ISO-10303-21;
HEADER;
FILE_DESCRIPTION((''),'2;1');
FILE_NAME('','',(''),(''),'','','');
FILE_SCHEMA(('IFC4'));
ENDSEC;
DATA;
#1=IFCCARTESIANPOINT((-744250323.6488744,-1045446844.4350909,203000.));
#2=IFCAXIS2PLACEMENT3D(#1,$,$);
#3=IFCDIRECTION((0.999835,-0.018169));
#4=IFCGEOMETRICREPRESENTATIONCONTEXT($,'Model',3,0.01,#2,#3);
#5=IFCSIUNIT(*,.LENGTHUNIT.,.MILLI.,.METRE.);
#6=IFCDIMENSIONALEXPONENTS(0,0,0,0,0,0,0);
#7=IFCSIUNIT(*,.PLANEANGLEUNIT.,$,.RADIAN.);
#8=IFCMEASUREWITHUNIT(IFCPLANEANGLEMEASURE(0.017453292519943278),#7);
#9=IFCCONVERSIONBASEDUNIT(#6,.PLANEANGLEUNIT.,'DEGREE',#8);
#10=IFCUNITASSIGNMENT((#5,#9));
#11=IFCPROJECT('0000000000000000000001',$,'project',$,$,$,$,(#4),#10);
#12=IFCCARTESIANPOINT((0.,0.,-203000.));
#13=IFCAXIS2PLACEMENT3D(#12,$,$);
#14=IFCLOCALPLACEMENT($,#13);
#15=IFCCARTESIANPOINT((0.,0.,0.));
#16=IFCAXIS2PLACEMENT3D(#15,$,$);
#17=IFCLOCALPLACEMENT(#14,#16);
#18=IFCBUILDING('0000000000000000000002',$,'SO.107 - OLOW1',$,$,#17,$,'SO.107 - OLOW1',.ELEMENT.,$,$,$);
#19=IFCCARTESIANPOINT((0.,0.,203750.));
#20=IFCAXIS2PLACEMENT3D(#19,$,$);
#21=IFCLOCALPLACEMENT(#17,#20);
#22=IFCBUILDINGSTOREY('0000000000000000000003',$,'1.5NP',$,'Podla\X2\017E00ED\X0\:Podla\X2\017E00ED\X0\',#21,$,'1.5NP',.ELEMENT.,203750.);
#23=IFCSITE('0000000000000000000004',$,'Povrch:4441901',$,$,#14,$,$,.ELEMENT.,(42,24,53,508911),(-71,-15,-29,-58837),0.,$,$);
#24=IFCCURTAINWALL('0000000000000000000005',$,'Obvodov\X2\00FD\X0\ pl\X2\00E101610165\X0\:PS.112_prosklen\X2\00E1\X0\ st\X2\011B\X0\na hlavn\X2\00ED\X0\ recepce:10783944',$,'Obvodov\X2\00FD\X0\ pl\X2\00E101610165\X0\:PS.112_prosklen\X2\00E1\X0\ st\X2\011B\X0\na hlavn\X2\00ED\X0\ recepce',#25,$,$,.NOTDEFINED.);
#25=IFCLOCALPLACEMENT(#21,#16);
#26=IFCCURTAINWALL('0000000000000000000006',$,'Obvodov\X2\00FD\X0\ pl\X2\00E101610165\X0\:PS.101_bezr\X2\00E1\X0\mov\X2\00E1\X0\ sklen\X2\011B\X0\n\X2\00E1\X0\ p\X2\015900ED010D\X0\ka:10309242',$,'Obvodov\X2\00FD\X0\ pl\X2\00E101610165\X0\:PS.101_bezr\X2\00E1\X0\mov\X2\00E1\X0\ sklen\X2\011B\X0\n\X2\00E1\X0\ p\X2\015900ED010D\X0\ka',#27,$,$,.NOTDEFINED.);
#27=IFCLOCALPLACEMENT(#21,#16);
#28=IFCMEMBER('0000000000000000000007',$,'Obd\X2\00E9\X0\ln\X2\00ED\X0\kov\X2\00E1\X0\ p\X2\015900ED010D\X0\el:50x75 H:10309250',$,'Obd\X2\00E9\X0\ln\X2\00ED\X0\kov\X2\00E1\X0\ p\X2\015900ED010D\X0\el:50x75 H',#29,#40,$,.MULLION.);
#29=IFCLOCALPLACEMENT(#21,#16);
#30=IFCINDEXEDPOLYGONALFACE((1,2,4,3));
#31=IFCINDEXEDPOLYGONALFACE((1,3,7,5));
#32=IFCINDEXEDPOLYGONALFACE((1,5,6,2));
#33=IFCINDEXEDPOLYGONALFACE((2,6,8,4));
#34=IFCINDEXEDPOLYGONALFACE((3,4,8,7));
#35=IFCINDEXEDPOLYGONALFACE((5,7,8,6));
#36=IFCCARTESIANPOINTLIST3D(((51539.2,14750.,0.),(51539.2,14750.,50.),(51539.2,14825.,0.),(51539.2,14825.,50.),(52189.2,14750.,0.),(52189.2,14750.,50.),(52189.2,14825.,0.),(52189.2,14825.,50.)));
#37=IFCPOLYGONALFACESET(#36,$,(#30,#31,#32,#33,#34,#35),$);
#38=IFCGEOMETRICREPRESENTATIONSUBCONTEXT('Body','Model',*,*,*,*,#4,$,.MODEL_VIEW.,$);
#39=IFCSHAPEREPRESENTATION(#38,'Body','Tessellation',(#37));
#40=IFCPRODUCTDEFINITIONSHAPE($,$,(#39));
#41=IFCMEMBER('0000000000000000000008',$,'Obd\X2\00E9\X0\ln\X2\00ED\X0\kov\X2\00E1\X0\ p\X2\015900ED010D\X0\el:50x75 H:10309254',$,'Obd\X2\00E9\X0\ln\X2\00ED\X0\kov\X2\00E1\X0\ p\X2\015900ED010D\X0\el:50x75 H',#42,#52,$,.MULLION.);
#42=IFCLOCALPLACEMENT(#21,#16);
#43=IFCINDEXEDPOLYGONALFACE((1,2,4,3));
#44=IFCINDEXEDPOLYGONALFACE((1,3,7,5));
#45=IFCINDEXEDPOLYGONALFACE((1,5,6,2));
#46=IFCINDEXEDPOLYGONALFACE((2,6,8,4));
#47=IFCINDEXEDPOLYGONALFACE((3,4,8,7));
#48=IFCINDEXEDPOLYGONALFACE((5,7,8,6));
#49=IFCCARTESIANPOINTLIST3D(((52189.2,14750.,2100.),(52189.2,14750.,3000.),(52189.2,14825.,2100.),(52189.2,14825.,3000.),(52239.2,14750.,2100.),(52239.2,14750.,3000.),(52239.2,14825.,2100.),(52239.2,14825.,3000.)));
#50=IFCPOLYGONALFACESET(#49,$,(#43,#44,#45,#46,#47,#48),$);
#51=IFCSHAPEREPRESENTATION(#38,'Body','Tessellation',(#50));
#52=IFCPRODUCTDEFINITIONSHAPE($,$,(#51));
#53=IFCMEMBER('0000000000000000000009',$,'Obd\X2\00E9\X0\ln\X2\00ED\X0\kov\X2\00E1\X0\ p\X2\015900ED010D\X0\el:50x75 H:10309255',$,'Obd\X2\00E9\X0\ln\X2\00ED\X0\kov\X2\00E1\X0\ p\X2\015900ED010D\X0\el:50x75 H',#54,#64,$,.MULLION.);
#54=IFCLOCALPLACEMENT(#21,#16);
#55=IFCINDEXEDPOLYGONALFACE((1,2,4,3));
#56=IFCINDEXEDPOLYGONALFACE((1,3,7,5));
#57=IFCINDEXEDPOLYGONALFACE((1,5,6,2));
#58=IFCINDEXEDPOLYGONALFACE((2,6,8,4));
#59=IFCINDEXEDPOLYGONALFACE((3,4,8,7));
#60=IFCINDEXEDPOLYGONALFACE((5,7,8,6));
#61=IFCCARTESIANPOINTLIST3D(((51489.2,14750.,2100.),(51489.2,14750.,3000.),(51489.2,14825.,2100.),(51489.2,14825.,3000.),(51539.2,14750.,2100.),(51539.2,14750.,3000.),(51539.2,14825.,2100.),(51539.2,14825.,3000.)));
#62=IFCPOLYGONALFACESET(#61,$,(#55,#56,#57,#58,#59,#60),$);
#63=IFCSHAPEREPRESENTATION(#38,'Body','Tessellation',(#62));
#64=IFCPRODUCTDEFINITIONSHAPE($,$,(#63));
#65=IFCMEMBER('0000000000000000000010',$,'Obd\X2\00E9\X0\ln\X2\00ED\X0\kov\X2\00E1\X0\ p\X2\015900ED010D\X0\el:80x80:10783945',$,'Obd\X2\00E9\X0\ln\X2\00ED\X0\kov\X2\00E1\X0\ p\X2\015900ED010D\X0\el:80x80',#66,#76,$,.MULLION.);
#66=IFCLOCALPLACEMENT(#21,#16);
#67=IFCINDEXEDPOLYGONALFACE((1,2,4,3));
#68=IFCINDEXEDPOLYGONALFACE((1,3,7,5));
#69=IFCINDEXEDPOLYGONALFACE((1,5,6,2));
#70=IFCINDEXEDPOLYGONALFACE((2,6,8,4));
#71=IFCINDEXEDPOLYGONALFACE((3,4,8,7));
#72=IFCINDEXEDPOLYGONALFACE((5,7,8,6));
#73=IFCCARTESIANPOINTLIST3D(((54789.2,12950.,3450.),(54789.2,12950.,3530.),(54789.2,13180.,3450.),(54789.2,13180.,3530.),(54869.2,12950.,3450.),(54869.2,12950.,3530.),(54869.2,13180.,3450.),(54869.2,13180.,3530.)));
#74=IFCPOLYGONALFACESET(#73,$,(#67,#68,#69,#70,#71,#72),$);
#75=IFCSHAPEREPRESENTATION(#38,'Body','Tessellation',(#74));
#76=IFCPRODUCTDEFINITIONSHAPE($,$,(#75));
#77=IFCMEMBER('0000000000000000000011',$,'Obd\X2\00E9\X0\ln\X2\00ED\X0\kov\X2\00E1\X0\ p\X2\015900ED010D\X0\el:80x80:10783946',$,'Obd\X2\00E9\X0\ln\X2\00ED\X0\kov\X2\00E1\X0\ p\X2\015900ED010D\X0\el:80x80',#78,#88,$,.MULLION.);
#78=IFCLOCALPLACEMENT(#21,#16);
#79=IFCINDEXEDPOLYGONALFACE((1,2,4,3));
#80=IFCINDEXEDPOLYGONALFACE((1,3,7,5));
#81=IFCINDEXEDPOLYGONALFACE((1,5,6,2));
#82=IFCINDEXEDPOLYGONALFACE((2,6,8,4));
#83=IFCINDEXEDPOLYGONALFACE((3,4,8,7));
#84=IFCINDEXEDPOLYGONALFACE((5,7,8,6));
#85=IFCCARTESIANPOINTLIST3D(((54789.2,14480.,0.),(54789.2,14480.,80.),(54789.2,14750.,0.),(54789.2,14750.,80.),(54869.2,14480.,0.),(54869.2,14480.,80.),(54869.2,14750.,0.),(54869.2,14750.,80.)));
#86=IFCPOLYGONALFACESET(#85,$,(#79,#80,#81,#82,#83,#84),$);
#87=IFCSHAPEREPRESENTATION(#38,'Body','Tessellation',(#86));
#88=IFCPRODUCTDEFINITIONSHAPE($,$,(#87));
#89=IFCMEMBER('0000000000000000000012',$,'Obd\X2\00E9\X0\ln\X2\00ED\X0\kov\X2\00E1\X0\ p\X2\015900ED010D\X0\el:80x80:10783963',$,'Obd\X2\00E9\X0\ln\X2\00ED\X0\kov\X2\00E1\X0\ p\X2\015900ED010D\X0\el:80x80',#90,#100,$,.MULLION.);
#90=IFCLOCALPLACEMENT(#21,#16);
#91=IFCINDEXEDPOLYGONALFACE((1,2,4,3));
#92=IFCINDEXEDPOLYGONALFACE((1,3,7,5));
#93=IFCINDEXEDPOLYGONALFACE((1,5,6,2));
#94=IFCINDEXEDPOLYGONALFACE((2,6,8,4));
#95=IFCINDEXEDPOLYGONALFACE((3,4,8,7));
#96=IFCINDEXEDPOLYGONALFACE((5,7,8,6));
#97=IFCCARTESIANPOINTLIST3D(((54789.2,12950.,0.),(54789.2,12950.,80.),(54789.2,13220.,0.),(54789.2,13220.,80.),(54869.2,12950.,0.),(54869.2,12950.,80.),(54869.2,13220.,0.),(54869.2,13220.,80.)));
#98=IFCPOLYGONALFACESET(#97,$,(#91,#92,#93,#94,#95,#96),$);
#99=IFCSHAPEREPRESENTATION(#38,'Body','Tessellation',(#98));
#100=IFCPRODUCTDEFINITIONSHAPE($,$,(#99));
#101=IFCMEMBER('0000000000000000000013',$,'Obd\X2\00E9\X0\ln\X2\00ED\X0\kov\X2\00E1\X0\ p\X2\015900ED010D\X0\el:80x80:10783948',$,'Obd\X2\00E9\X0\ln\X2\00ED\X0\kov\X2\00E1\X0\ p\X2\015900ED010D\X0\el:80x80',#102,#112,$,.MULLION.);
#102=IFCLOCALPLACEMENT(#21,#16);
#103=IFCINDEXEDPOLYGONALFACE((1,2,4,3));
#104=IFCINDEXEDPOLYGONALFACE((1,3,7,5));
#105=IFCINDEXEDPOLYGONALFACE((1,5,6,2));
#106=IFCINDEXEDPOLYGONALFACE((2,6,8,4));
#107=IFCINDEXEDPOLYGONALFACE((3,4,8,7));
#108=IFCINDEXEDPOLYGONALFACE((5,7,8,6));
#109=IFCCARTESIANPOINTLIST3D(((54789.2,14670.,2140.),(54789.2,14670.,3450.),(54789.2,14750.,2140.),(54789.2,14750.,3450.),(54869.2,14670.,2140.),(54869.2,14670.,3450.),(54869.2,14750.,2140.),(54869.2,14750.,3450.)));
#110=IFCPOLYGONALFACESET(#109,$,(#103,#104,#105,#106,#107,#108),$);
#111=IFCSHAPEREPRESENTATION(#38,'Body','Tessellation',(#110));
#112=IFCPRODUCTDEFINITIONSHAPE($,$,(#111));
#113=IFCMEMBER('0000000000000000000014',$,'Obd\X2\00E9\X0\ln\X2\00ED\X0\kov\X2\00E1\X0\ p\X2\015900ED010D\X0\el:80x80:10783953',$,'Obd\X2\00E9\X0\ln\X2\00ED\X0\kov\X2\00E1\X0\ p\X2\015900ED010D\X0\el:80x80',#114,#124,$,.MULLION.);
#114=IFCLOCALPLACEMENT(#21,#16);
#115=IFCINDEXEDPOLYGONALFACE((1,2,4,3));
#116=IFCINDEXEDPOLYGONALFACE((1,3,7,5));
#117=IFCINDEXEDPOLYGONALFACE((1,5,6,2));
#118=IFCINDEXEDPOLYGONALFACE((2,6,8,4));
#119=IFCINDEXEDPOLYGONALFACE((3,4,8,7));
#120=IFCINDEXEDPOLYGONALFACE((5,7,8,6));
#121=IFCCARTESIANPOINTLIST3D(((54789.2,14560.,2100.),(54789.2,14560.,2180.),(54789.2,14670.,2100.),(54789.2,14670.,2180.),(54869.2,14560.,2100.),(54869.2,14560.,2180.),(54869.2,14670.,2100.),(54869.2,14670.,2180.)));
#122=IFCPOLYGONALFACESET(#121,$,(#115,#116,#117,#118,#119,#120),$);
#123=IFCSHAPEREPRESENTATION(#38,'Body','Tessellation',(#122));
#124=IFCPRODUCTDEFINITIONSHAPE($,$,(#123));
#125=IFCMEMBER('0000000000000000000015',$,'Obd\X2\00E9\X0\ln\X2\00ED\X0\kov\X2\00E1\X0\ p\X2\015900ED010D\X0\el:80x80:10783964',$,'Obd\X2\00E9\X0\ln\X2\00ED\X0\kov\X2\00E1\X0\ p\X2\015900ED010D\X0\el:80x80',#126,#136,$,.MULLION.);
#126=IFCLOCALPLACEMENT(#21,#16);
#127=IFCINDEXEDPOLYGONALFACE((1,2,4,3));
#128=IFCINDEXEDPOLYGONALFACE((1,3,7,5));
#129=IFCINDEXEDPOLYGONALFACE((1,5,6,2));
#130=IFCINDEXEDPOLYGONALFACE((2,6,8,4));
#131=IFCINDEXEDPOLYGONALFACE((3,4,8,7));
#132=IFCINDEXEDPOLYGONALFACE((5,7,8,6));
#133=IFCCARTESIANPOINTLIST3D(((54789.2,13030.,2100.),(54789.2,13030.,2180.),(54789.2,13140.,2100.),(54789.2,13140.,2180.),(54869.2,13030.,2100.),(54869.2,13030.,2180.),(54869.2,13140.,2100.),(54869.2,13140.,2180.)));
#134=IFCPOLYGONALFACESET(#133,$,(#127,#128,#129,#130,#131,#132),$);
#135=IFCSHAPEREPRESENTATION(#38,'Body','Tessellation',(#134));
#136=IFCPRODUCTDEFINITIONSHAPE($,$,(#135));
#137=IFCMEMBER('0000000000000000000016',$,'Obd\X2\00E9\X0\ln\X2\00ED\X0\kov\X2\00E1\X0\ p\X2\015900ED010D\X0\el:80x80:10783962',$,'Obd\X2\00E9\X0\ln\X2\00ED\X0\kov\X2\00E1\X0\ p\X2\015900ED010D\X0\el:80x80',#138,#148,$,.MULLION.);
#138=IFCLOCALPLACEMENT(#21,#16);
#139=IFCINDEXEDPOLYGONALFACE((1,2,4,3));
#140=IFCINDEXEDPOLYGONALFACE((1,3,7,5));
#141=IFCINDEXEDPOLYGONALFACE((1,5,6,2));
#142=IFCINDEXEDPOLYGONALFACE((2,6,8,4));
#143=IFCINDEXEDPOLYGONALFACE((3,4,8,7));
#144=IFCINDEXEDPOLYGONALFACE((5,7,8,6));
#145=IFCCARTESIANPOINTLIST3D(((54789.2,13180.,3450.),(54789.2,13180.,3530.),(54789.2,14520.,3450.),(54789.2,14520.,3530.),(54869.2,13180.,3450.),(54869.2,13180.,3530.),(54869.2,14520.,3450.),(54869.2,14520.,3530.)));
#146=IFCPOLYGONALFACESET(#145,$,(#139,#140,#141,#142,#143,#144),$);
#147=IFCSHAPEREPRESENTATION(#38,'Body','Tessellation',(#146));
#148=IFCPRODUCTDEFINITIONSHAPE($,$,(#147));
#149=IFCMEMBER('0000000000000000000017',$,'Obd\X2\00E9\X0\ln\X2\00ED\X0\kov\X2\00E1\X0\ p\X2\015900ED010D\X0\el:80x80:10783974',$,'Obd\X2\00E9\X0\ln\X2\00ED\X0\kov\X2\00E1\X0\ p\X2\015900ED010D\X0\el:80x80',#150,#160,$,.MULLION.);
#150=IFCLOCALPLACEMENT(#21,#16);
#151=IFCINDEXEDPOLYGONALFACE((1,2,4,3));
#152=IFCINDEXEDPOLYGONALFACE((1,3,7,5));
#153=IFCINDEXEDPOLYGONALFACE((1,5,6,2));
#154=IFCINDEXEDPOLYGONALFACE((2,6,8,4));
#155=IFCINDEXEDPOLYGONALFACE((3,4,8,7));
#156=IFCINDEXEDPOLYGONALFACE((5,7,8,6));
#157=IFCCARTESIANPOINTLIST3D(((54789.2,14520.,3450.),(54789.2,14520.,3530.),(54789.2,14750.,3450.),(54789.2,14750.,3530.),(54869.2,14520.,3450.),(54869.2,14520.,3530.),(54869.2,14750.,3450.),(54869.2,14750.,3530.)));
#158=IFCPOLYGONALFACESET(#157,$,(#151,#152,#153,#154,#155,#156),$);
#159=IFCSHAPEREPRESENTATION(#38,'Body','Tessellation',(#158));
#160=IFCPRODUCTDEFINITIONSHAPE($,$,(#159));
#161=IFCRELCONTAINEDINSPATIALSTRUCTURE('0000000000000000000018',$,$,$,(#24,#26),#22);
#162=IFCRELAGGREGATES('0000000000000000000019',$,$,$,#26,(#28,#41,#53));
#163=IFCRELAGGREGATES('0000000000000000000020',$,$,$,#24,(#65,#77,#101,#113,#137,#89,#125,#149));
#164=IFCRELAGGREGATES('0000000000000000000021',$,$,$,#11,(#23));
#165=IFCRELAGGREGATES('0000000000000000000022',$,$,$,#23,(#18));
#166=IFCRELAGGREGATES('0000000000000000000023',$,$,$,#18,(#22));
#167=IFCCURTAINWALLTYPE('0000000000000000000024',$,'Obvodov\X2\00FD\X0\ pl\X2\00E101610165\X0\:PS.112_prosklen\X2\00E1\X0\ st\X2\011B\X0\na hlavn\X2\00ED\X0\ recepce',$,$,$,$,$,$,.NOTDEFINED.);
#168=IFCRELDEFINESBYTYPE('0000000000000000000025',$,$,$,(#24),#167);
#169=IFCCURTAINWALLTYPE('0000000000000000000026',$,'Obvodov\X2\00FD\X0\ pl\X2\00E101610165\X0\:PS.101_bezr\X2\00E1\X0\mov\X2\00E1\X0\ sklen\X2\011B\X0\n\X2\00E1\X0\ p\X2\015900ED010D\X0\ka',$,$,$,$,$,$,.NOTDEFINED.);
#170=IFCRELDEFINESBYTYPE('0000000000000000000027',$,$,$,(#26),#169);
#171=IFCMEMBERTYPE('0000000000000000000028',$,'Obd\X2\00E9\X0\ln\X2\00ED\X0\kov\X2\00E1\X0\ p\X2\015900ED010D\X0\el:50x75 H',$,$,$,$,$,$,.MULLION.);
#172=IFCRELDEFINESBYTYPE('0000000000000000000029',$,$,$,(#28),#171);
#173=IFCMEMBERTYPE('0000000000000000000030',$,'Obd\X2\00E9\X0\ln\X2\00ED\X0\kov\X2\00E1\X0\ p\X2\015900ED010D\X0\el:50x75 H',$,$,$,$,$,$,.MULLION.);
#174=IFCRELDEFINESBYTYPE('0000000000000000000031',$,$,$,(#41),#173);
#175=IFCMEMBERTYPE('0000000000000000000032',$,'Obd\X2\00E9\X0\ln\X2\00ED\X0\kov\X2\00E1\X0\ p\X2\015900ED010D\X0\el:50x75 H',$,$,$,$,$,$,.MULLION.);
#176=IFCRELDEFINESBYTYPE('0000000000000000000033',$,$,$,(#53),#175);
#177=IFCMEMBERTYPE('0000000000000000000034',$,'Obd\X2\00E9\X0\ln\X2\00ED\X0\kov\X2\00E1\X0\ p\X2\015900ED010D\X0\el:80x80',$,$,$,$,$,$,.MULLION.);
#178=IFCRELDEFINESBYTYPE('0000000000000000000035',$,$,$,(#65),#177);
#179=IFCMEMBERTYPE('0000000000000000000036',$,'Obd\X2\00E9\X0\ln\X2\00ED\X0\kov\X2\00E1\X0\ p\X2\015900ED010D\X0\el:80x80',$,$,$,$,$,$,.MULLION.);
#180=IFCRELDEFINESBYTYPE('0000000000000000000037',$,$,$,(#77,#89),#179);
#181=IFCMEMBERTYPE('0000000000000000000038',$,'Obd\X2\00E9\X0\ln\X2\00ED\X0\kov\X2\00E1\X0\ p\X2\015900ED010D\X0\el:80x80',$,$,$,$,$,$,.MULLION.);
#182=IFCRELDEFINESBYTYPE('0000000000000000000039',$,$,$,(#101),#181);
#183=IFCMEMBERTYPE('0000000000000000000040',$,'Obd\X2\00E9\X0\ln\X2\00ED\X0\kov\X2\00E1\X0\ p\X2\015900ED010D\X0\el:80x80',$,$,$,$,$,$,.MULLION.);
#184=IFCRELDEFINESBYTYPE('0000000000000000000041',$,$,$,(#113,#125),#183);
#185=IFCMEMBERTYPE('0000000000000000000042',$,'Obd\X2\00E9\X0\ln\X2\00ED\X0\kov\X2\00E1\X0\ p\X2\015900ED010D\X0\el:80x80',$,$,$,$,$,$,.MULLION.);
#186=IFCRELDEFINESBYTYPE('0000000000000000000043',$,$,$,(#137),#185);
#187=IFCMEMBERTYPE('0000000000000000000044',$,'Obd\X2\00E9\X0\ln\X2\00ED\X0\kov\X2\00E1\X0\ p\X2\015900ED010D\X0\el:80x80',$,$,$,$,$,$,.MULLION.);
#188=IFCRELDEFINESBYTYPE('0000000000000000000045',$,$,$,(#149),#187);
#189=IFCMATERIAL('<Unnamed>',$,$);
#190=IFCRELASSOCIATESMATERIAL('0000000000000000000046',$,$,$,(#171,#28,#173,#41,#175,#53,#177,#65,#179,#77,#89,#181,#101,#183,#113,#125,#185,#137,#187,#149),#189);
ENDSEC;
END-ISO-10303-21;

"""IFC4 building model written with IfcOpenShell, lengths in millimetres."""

from ifc_helpers import new_model, entity, si_unit, converted_unit, direction, frame, origin, place, context, subcontext, project, spatial, indexed_curve, outline, extrude, source, transform, mapped, material, type_object, type_shapes, element, aggregate, save


model = new_model("IFC4")

# Units and contexts
model_context = context("Model", 3, precision=0.01, world=frame((-744250323.6488744, -1045446844.4350909, 203000.0)), true_north=direction((0.999835, -0.018169)))
body_context = subcontext(model_context, "Body", "Model", "MODEL_VIEW")
ifc_project = project(units=[si_unit("LENGTHUNIT", "METRE", prefix="MILLI"), converted_unit("PLANEANGLEUNIT", "DEGREE", entity("IfcPlaneAngleMeasure", 0.017453292519943278), si_unit("PLANEANGLEUNIT", "RADIAN"), dimensions=[0, 0, 0, 0, 0, 0, 0])], contexts=[model_context])

# Site, building, storey
site_placement = place(None, frame((0.0, 0.0, -203000.0)))
site = spatial("IfcSite", under=ifc_project, at=site_placement, Name="Povrch:4441901", CompositionType="ELEMENT", RefLatitude=(42, 24, 53, 508911), RefLongitude=(-71, -15, -29, -58837), RefElevation=0.0)
building_placement = place(site_placement, origin())
building = spatial("IfcBuilding", under=site, at=building_placement, Name="SO.107 - OLOW1", LongName="SO.107 - OLOW1", CompositionType="ELEMENT")
storey_placement = place(building_placement, frame((0.0, 0.0, 203750.0)))
storey = spatial("IfcBuildingStorey", under=building, at=storey_placement, Name="1.5NP", ObjectType="Podlaží:Podlaží", LongName="1.5NP", CompositionType="ELEMENT", Elevation=203750.0)

# Curtain walls, members
curtain_wall_type_1 = type_object("IfcCurtainWallType", Name="Obvodový plášť:PS.112_prosklená stěna hlavní recepce", PredefinedType="NOTDEFINED")
curtain_wall_1_placement = place(storey_placement, frame((0.0, 0.0, -203750.0)))
curtain_wall_1 = element("IfcCurtainWall", 1, at=curtain_wall_1_placement, inside=storey, type_object=curtain_wall_type_1, Name="Obvodový plášť:PS.112_prosklená stěna hlavní recepce:10783944", ObjectType="Obvodový plášť:PS.112_prosklená stěna hlavní recepce", PredefinedType="NOTDEFINED")
ifc_material_1 = material(Name="<Unnamed>")
curtain_wall_type_2 = type_object("IfcCurtainWallType", Name="Obvodový plášť:PS.101_bezrámová skleněná příčka", PredefinedType="NOTDEFINED")
curtain_wall_2_placement = place(storey_placement, frame((0.0, 0.0, -203750.0)))
curtain_wall_2 = element("IfcCurtainWall", 2, at=curtain_wall_2_placement, inside=storey, type_object=curtain_wall_type_2, Name="Obvodový plášť:PS.101_bezrámová skleněná příčka:10309242", ObjectType="Obvodový plášť:PS.101_bezrámová skleněná příčka", PredefinedType="NOTDEFINED")
member_type_1 = type_object("IfcMemberType", Name="Obdélníková příčel:50x75 H", PredefinedType="MULLION", material=ifc_material_1)
shared_shape_1 = source(origin(), body_context, "Body", "SweptSolid", [
    extrude(outline(indexed_curve([(-25.0, -37.5), (25.0, -37.5), (25.0, 37.5), (-25.0, 37.5), (-25.0, -37.5)], self_intersect=False)), frame((-25.0, -37.5, -650.0), z_axis=(0.0, 0.0, 1.0), x_axis=(-1.0, 0.0, 0.0)), (0.0, 0.0, 1.0), 650.0),
])
type_shapes(member_type_1, [shared_shape_1])
member_1_placement = place(curtain_wall_2_placement, frame((51539.2, 14750.0, 203750.0), z_axis=(-1.0, 0.0, 0.0), x_axis=(0.0, 0.0, -1.0)))
member_1 = element("IfcMember", 3, at=member_1_placement, type_object=member_type_1, material=ifc_material_1, Name="Obdélníková příčel:50x75 H:10309250", ObjectType="Obdélníková příčel:50x75 H", PredefinedType="MULLION", context=body_context, shape_type="MappedRepresentation", body=[
    mapped(shared_shape_1, transform((0.0, 0.0, 0.0), scale=1.0)),
])
member_type_2 = type_object("IfcMemberType", Name="Obdélníková příčel:50x75 H", PredefinedType="MULLION", material=ifc_material_1)
shared_shape_2 = source(origin(), body_context, "Body", "SweptSolid", [
    extrude(outline(indexed_curve([(-25.0, -37.5), (25.0, -37.5), (25.0, 37.5), (-25.0, 37.5), (-25.0, -37.5)], self_intersect=False)), frame((-25.0, -37.5, -900.0), z_axis=(0.0, 0.0, 1.0), x_axis=(-1.0, 0.0, 0.0)), (0.0, 0.0, 1.0), 900.0),
])
type_shapes(member_type_2, [shared_shape_2])
member_2_placement = place(curtain_wall_2_placement, frame((52239.2, 14750.0, 205850.0), z_axis=(0.0, 0.0, -1.0), x_axis=(1.0, 0.0, 0.0)))
member_2 = element("IfcMember", 4, at=member_2_placement, type_object=member_type_2, material=ifc_material_1, Name="Obdélníková příčel:50x75 H:10309254", ObjectType="Obdélníková příčel:50x75 H", PredefinedType="MULLION", context=body_context, shape_type="MappedRepresentation", body=[
    mapped(shared_shape_2, transform((0.0, 0.0, 0.0), scale=1.0)),
])
member_type_3 = type_object("IfcMemberType", Name="Obdélníková příčel:50x75 H", PredefinedType="MULLION", material=ifc_material_1)
shared_shape_3 = source(origin(), body_context, "Body", "SweptSolid", [
    extrude(outline(indexed_curve([(-25.0, -37.5), (25.0, -37.5), (25.0, 37.5), (-25.0, 37.5), (-25.0, -37.5)], self_intersect=False)), frame((-25.0, -37.5, -900.0), z_axis=(0.0, 0.0, 1.0), x_axis=(-1.0, 0.0, 0.0)), (0.0, 0.0, 1.0), 900.0),
])
type_shapes(member_type_3, [shared_shape_3])
member_3_placement = place(curtain_wall_2_placement, frame((51539.2, 14750.0, 205850.0), z_axis=(0.0, 0.0, -1.0), x_axis=(1.0, 0.0, 0.0)))
member_3 = element("IfcMember", 5, at=member_3_placement, type_object=member_type_3, material=ifc_material_1, Name="Obdélníková příčel:50x75 H:10309255", ObjectType="Obdélníková příčel:50x75 H", PredefinedType="MULLION", context=body_context, shape_type="MappedRepresentation", body=[
    mapped(shared_shape_3, transform((0.0, 0.0, 0.0), scale=1.0)),
])

# Members
member_type_4 = type_object("IfcMemberType", Name="Obdélníková příčel:80x80", PredefinedType="MULLION", material=ifc_material_1)
shared_shape_4 = source(origin(), body_context, "Body", "SweptSolid", [
    extrude(outline(indexed_curve([(-40.0, -40.0), (40.0, -40.0), (40.0, 40.0), (-40.0, 40.0), (-40.0, -40.0)], self_intersect=False)), frame((-40.0, 0.0, -230.0), z_axis=(0.0, 0.0, 1.0), x_axis=(-1.0, 0.0, 0.0)), (0.0, 0.0, 1.0), 230.0),
])
type_shapes(member_type_4, [shared_shape_4])
member_4_placement = place(curtain_wall_1_placement, frame((54829.2, 12950.0, 207280.0), z_axis=(0.0, -1.0, 0.0), x_axis=(0.0, 0.0, 1.0)))
member_4 = element("IfcMember", 6, at=member_4_placement, type_object=member_type_4, material=ifc_material_1, Name="Obdélníková příčel:80x80:10783945", ObjectType="Obdélníková příčel:80x80", PredefinedType="MULLION", context=body_context, shape_type="MappedRepresentation", body=[
    mapped(shared_shape_4, transform((0.0, 0.0, 0.0), scale=1.0)),
])
member_type_5 = type_object("IfcMemberType", Name="Obdélníková příčel:80x80", PredefinedType="MULLION", material=ifc_material_1)
shared_shape_5 = source(origin(), body_context, "Body", "SweptSolid", [
    extrude(outline(indexed_curve([(-40.0, -40.0), (40.0, -40.0), (40.0, 40.0), (-40.0, 40.0), (-40.0, -40.0)], self_intersect=False)), frame((-40.0, 0.0, -270.0), z_axis=(0.0, 0.0, 1.0), x_axis=(-1.0, 0.0, 0.0)), (0.0, 0.0, 1.0), 270.0),
])
type_shapes(member_type_5, [shared_shape_5])
member_5_placement = place(curtain_wall_1_placement, frame((54829.2, 14750.0, 203750.0), z_axis=(0.0, 1.0, 0.0), x_axis=(0.0, 0.0, -1.0)))
member_5 = element("IfcMember", 7, at=member_5_placement, type_object=member_type_5, material=ifc_material_1, Name="Obdélníková příčel:80x80:10783946", ObjectType="Obdélníková příčel:80x80", PredefinedType="MULLION", context=body_context, shape_type="MappedRepresentation", body=[
    mapped(shared_shape_5, transform((0.0, 0.0, 0.0), scale=1.0)),
])
member_6_placement = place(curtain_wall_1_placement, frame((54829.2, 13220.0, 203750.0), z_axis=(0.0, 1.0, 0.0), x_axis=(0.0, 0.0, -1.0)))
member_6 = element("IfcMember", 8, at=member_6_placement, type_object=member_type_5, material=ifc_material_1, Name="Obdélníková příčel:80x80:10783963", ObjectType="Obdélníková příčel:80x80", PredefinedType="MULLION", context=body_context, shape_type="MappedRepresentation", body=[
    mapped(shared_shape_5, transform((0.0, 0.0, 0.0), scale=1.0)),
])
member_type_6 = type_object("IfcMemberType", Name="Obdélníková příčel:80x80", PredefinedType="MULLION", material=ifc_material_1)
shared_shape_6 = source(origin(), body_context, "Body", "SweptSolid", [
    extrude(outline(indexed_curve([(-40.0, -40.0), (40.0, -40.0), (40.0, 40.0), (-40.0, 40.0), (-40.0, -40.0)], self_intersect=False)), frame((-40.0, 0.0, -1310.0), z_axis=(0.0, 0.0, 1.0), x_axis=(-1.0, 0.0, 0.0)), (0.0, 0.0, 1.0), 1310.0),
])
type_shapes(member_type_6, [shared_shape_6])
member_7_placement = place(curtain_wall_1_placement, frame((54829.2, 14750.0, 207200.0), z_axis=(0.0, 0.0, 1.0), x_axis=(0.0, 1.0, 0.0)))
member_7 = element("IfcMember", 9, at=member_7_placement, type_object=member_type_6, material=ifc_material_1, Name="Obdélníková příčel:80x80:10783948", ObjectType="Obdélníková příčel:80x80", PredefinedType="MULLION", context=body_context, shape_type="MappedRepresentation", body=[
    mapped(shared_shape_6, transform((0.0, 0.0, 0.0), scale=1.0)),
])
member_type_7 = type_object("IfcMemberType", Name="Obdélníková příčel:80x80", PredefinedType="MULLION", material=ifc_material_1)
shared_shape_7 = source(origin(), body_context, "Body", "SweptSolid", [
    extrude(outline(indexed_curve([(-40.0, -40.0), (40.0, -40.0), (40.0, 40.0), (-40.0, 40.0), (-40.0, -40.0)], self_intersect=False)), frame((0.0, 0.0, -110.0), z_axis=(0.0, 0.0, 1.0), x_axis=(-1.0, 0.0, 0.0)), (0.0, 0.0, 1.0), 110.0),
])
type_shapes(member_type_7, [shared_shape_7])
member_8_placement = place(curtain_wall_1_placement, frame((54829.2, 14560.0, 205890.0), z_axis=(0.0, -1.0, 0.0), x_axis=(0.0, 0.0, 1.0)))
member_8 = element("IfcMember", 10, at=member_8_placement, type_object=member_type_7, material=ifc_material_1, Name="Obdélníková příčel:80x80:10783953", ObjectType="Obdélníková příčel:80x80", PredefinedType="MULLION", context=body_context, shape_type="MappedRepresentation", body=[
    mapped(shared_shape_7, transform((0.0, 0.0, 0.0), scale=1.0)),
])
member_9_placement = place(curtain_wall_1_placement, frame((54829.2, 13030.0, 205890.0), z_axis=(0.0, -1.0, 0.0), x_axis=(0.0, 0.0, 1.0)))
member_9 = element("IfcMember", 11, at=member_9_placement, type_object=member_type_7, material=ifc_material_1, Name="Obdélníková příčel:80x80:10783964", ObjectType="Obdélníková příčel:80x80", PredefinedType="MULLION", context=body_context, shape_type="MappedRepresentation", body=[
    mapped(shared_shape_7, transform((0.0, 0.0, 0.0), scale=1.0)),
])
member_type_8 = type_object("IfcMemberType", Name="Obdélníková příčel:80x80", PredefinedType="MULLION", material=ifc_material_1)
shared_shape_8 = source(origin(), body_context, "Body", "SweptSolid", [
    extrude(outline(indexed_curve([(-40.0, -40.0), (40.0, -40.0), (40.0, 40.0), (-40.0, 40.0), (-40.0, -40.0)], self_intersect=False)), frame((-40.0, 0.0, -1340.0), z_axis=(0.0, 0.0, 1.0), x_axis=(-1.0, 0.0, 0.0)), (0.0, 0.0, 1.0), 1340.0),
])
type_shapes(member_type_8, [shared_shape_8])
member_10_placement = place(curtain_wall_1_placement, frame((54829.2, 13180.0, 207280.0), z_axis=(0.0, -1.0, 0.0), x_axis=(0.0, 0.0, 1.0)))
member_10 = element("IfcMember", 12, at=member_10_placement, type_object=member_type_8, material=ifc_material_1, Name="Obdélníková příčel:80x80:10783962", ObjectType="Obdélníková příčel:80x80", PredefinedType="MULLION", context=body_context, shape_type="MappedRepresentation", body=[
    mapped(shared_shape_8, transform((0.0, 0.0, 0.0), scale=1.0)),
])
member_type_9 = type_object("IfcMemberType", Name="Obdélníková příčel:80x80", PredefinedType="MULLION", material=ifc_material_1)
shared_shape_9 = source(origin(), body_context, "Body", "SweptSolid", [
    extrude(outline(indexed_curve([(-40.0, -40.0), (40.0, -40.0), (40.0, 40.0), (-40.0, 40.0), (-40.0, -40.0)], self_intersect=False)), frame((-40.0, 0.0, -230.0), z_axis=(0.0, 0.0, 1.0), x_axis=(-1.0, 0.0, 0.0)), (0.0, 0.0, 1.0), 230.0),
])
type_shapes(member_type_9, [shared_shape_9])
member_11_placement = place(curtain_wall_1_placement, frame((54829.2, 14520.0, 207280.0), z_axis=(0.0, -1.0, 0.0), x_axis=(0.0, 0.0, 1.0)))
member_11 = element("IfcMember", 13, at=member_11_placement, type_object=member_type_9, material=ifc_material_1, Name="Obdélníková příčel:80x80:10783974", ObjectType="Obdélníková příčel:80x80", PredefinedType="MULLION", context=body_context, shape_type="MappedRepresentation", body=[
    mapped(shared_shape_9, transform((0.0, 0.0, 0.0), scale=1.0)),
])

aggregate(curtain_wall_2, [member_1, member_2, member_3])
aggregate(curtain_wall_1, [member_4, member_5, member_7, member_8, member_10, member_6, member_9, member_11])

save(model, "model.ifc")
